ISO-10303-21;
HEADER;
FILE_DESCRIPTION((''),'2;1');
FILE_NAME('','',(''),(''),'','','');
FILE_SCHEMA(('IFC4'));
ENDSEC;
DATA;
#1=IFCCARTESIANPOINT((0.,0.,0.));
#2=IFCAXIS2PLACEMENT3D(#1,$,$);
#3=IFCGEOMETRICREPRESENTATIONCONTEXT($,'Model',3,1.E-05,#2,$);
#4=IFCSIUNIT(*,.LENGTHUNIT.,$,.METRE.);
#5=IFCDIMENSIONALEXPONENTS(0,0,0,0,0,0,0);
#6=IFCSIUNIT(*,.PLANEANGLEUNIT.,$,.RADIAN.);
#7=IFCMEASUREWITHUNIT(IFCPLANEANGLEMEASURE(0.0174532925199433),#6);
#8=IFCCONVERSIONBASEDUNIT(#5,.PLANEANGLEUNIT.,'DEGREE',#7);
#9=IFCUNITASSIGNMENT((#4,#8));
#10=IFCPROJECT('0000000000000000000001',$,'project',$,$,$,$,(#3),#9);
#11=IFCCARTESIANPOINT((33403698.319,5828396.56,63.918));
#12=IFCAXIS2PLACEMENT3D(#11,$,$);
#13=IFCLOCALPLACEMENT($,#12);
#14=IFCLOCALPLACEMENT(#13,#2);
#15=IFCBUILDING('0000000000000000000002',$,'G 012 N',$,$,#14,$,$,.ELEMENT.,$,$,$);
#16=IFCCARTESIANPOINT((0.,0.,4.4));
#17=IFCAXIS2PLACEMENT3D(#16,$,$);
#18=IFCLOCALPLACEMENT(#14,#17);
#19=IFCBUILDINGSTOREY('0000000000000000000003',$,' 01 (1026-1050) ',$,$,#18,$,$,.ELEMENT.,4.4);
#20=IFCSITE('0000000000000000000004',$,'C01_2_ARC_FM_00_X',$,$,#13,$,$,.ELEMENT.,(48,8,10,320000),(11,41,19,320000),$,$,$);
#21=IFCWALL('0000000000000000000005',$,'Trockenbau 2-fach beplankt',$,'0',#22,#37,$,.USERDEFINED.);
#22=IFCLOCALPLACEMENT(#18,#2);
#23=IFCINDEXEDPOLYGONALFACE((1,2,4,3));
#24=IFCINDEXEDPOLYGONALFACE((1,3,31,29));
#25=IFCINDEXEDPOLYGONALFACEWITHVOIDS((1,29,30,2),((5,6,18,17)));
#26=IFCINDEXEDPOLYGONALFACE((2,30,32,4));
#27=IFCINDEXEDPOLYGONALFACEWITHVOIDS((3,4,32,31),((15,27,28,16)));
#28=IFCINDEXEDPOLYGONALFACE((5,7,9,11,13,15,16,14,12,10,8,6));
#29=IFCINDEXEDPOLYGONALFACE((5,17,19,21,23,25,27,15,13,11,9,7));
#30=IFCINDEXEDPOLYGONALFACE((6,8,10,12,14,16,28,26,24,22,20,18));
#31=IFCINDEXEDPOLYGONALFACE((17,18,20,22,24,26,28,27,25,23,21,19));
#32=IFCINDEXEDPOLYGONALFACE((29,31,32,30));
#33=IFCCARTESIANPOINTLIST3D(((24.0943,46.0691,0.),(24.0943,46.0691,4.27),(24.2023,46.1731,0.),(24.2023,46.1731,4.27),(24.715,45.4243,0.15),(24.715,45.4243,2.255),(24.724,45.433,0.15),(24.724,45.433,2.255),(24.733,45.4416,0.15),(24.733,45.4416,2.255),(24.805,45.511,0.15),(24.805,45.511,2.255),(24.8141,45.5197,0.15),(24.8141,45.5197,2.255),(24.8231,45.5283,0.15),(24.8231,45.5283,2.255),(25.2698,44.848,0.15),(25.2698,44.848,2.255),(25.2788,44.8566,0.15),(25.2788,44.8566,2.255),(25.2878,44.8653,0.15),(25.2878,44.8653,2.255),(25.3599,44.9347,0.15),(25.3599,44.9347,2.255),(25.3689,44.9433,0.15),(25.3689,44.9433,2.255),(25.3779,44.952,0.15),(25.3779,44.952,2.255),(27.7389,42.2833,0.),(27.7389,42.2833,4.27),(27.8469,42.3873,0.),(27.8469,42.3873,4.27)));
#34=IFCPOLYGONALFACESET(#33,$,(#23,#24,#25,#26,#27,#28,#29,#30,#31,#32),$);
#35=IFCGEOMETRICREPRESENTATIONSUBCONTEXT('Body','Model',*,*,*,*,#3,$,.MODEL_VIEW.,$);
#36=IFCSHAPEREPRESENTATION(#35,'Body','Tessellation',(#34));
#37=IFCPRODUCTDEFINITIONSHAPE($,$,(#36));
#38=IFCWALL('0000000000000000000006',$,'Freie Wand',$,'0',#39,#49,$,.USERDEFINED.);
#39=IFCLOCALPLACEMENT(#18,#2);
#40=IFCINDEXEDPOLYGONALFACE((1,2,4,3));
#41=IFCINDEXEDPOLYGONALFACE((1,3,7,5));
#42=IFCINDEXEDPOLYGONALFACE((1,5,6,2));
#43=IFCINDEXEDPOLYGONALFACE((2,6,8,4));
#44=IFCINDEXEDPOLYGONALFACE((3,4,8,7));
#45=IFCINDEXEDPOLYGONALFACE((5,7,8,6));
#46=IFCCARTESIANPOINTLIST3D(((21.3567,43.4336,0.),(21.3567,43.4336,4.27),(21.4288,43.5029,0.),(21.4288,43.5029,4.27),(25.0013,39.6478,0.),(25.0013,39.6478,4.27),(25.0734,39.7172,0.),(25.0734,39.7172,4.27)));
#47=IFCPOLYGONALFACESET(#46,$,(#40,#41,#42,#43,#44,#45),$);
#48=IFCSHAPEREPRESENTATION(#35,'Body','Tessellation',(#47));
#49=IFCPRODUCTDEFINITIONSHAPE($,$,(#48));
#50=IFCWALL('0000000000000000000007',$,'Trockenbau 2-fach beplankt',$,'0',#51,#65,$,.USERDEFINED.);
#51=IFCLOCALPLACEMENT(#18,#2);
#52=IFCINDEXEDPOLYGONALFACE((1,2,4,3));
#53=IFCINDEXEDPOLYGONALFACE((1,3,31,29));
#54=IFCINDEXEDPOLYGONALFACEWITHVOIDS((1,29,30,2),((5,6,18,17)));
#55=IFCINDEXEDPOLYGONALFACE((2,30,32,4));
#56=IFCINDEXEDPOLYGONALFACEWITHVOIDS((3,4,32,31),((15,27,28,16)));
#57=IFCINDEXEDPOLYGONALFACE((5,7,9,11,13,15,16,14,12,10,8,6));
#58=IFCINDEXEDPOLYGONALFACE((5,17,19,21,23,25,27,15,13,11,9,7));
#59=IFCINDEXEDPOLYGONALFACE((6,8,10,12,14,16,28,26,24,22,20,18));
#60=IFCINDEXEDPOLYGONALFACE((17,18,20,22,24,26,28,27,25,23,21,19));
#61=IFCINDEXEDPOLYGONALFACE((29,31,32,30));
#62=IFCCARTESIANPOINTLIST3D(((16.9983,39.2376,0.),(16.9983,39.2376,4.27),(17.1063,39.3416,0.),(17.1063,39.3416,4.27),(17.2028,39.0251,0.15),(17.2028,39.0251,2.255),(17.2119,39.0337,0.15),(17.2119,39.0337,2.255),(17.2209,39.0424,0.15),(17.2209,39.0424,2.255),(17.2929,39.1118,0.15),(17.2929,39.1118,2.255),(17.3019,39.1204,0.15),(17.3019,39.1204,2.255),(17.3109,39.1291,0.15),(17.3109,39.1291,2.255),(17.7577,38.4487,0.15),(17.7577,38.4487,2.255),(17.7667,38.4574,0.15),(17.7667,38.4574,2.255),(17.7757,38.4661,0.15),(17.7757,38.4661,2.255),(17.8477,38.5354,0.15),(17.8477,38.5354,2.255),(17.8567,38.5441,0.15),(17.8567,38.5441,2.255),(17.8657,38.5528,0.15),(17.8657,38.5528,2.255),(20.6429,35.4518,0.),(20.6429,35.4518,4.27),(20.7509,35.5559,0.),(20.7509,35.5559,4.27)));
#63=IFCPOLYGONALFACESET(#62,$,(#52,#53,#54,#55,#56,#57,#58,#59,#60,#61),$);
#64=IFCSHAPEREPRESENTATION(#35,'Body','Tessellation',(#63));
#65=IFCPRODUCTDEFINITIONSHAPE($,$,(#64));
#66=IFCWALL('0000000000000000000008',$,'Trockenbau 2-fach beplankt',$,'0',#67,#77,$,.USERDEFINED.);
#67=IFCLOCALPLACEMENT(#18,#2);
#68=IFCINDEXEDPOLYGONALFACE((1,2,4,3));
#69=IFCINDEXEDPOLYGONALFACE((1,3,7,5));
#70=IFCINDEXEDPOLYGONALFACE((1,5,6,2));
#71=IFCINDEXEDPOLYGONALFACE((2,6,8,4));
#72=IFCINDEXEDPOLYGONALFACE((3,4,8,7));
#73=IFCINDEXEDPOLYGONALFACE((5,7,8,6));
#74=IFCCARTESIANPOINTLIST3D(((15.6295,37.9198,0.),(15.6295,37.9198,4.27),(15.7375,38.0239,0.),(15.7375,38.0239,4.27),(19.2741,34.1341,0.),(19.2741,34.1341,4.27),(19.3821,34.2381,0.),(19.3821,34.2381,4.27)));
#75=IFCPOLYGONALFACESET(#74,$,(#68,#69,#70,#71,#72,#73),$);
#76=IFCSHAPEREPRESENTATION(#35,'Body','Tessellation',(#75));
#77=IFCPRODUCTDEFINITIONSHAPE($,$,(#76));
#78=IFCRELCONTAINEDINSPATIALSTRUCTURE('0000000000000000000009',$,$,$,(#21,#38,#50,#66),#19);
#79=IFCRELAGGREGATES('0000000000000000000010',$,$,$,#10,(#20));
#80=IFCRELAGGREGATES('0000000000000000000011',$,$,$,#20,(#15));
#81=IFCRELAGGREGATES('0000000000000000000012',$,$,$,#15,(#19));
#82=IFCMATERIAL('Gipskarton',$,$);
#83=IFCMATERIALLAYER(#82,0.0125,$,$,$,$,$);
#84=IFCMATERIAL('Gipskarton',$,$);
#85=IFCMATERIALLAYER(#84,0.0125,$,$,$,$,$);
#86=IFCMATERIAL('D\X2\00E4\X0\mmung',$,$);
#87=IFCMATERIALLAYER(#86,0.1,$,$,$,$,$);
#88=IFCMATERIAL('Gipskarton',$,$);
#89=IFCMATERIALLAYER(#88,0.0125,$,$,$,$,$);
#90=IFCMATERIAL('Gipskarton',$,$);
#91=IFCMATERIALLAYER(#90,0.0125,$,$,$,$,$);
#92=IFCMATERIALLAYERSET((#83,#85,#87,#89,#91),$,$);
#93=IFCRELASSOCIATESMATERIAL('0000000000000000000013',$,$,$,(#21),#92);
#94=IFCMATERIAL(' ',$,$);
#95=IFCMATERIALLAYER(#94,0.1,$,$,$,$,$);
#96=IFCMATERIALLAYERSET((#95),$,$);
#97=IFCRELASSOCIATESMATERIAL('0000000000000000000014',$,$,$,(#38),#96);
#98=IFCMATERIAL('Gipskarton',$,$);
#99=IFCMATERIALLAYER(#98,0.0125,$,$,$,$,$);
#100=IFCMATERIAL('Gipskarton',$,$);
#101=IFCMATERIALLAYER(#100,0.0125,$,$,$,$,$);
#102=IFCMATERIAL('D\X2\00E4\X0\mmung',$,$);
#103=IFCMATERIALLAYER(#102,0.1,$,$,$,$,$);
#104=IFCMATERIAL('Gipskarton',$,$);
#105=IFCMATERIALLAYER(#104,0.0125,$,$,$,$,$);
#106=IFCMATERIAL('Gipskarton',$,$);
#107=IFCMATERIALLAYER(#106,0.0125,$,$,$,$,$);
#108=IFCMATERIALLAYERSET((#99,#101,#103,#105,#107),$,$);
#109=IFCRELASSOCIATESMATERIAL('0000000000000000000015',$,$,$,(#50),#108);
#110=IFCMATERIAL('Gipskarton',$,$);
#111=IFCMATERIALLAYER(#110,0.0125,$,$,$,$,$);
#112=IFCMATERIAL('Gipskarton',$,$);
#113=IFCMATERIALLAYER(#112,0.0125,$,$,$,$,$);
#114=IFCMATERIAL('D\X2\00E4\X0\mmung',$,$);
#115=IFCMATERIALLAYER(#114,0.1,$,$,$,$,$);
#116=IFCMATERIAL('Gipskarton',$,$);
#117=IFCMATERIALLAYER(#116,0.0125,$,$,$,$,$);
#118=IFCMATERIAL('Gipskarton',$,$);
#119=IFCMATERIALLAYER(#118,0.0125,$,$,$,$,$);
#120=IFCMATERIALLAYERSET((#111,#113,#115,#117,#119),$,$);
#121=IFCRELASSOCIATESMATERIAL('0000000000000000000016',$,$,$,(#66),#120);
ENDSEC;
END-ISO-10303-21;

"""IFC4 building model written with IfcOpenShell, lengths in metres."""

from ifc_helpers import new_model, entity, si_unit, converted_unit, frame, frame_2d, origin, origin_with_axes, place, context, subcontext, project, spatial, polyline, rectangle, outline, extrude, material, layer, layer_set, layer_usage, element, save


model = new_model("IFC4")

# Units and contexts
model_context = context("Model", 3, precision=1e-05, world=origin())
body_context = subcontext(model_context, "Body", "Model", "MODEL_VIEW")
ifc_project = project(units=[si_unit("LENGTHUNIT", "METRE"), converted_unit("PLANEANGLEUNIT", "DEGREE", entity("IfcPlaneAngleMeasure", 0.0174532925199433), si_unit("PLANEANGLEUNIT", "RADIAN"), dimensions=[0, 0, 0, 0, 0, 0, 0])], contexts=[model_context])

# Site, building, storey
site_placement = place(None, frame((33403698.319, 5828396.56, 63.918)))
site = spatial("IfcSite", under=ifc_project, at=site_placement, Name="C01_2_ARC_FM_00_X", CompositionType="ELEMENT", RefLatitude=(48, 8, 10, 320000), RefLongitude=(11, 41, 19, 320000))
building_placement = place(site_placement, origin())
building = spatial("IfcBuilding", under=site, at=building_placement, Name="G 012 N", CompositionType="ELEMENT")
storey_placement = place(building_placement, frame((0.0, 0.0, 4.4)))
storey = spatial("IfcBuildingStorey", under=building, at=storey_placement, Name=" 01 (1026-1050) ", CompositionType="ELEMENT", Elevation=4.4)

# Wall, opening
ifc_material_1 = material(Name="Gipskarton")
ifc_layer_1 = layer(ifc_material_1, 0.0125)
ifc_material_2 = material(Name="Gipskarton")
ifc_layer_2 = layer(ifc_material_2, 0.0125)
ifc_material_3 = material(Name="Dämmung")
ifc_layer_3 = layer(ifc_material_3, 0.1)
ifc_material_4 = material(Name="Gipskarton")
ifc_layer_4 = layer(ifc_material_4, 0.0125)
ifc_material_5 = material(Name="Gipskarton")
ifc_layer_5 = layer(ifc_material_5, 0.0125)
ifc_layer_set_1 = layer_set([ifc_layer_1, ifc_layer_2, ifc_layer_3, ifc_layer_4, ifc_layer_5])
ifc_layer_usage_1 = layer_usage(ifc_layer_set_1, "AXIS2", "POSITIVE", 0.0)
wall_1_placement = place(storey_placement, frame((27.8469, 42.3873, 0.0), z_axis=(0.0, 0.0, 1.0), x_axis=(-0.693551, 0.720408, 0.0)))
wall_1 = element("IfcWall", 1, at=wall_1_placement, inside=storey, material=ifc_layer_usage_1, Name="Trockenbau 2-fach beplankt", ObjectType="0", PredefinedType="USERDEFINED", context=body_context, shape_type="SweptSolid", body=[
    extrude(rectangle(XDim=5.255, YDim=0.15, at=frame_2d((2.6275, 0.075), x_axis=(1.0, 0.0))), origin_with_axes(), (0.0, 0.0, 1.0), 4.27),
])
opening_1_placement = place(wall_1_placement, frame((4.36, 0.0125, 0.15), z_axis=(0.0, -1.0, 0.0), x_axis=(0.0, 0.0, 1.0)))
element("IfcOpeningElement", 2, at=opening_1_placement, cuts=wall_1, ObjectType="0", PredefinedType="USERDEFINED", context=body_context, shape_type="SweptSolid", body=[
    extrude(outline(polyline([(0.0, 0.8), (2.105, 0.8), (2.105, 0.0), (0.0, 0.0), (0.0, 0.8)])), origin_with_axes(), (0.0, 0.0, 1.0), 0.0125),
    extrude(outline(polyline([(0.0, 0.8), (2.105, 0.8), (2.105, 0.0), (0.0, 0.0), (0.0, 0.8)])), frame((0.0, 0.0, -0.0125), z_axis=(0.0, 0.0, 1.0), x_axis=(1.0, 0.0, 0.0)), (0.0, 0.0, 1.0), 0.0125),
    extrude(outline(polyline([(0.0, 0.8), (2.105, 0.8), (2.105, 0.0), (0.0, 0.0), (0.0, 0.8)])), frame((0.0, 0.0, -0.1125), z_axis=(0.0, 0.0, 1.0), x_axis=(1.0, 0.0, 0.0)), (0.0, 0.0, 1.0), 0.1),
    extrude(outline(polyline([(0.0, 0.8), (2.105, 0.8), (2.105, 0.0), (0.0, 0.0), (0.0, 0.8)])), frame((0.0, 0.0, -0.125), z_axis=(0.0, 0.0, 1.0), x_axis=(1.0, 0.0, 0.0)), (0.0, 0.0, 1.0), 0.0125),
    extrude(outline(polyline([(0.0, 0.8), (2.105, 0.8), (2.105, 0.0), (0.0, 0.0), (0.0, 0.8)])), frame((0.0, 0.0, -0.1375), z_axis=(0.0, 0.0, 1.0), x_axis=(1.0, 0.0, 0.0)), (0.0, 0.0, 1.0), 0.0125),
])

# Wall
ifc_material_6 = material(Name=" ")
ifc_layer_6 = layer(ifc_material_6, 0.1)
ifc_layer_set_2 = layer_set([ifc_layer_6])
ifc_layer_usage_2 = layer_usage(ifc_layer_set_2, "AXIS2", "POSITIVE", 0.0)
wall_2_placement = place(storey_placement, frame((25.0734, 39.7172, 0.0), z_axis=(0.0, 0.0, 1.0), x_axis=(-0.693551, 0.720408, 0.0)))
element("IfcWall", 3, at=wall_2_placement, inside=storey, material=ifc_layer_usage_2, Name="Freie Wand", ObjectType="0", PredefinedType="USERDEFINED", context=body_context, shape_type="SweptSolid", body=[
    extrude(rectangle(XDim=5.255, YDim=0.1, at=frame_2d((2.6275, 0.05), x_axis=(1.0, 0.0))), origin_with_axes(), (0.0, 0.0, 1.0), 4.27),
])

# Wall, opening
ifc_material_7 = material(Name="Gipskarton")
ifc_layer_7 = layer(ifc_material_7, 0.0125)
ifc_material_8 = material(Name="Gipskarton")
ifc_layer_8 = layer(ifc_material_8, 0.0125)
ifc_material_9 = material(Name="Dämmung")
ifc_layer_9 = layer(ifc_material_9, 0.1)
ifc_material_10 = material(Name="Gipskarton")
ifc_layer_10 = layer(ifc_material_10, 0.0125)
ifc_material_11 = material(Name="Gipskarton")
ifc_layer_11 = layer(ifc_material_11, 0.0125)
ifc_layer_set_3 = layer_set([ifc_layer_7, ifc_layer_8, ifc_layer_9, ifc_layer_10, ifc_layer_11])
ifc_layer_usage_3 = layer_usage(ifc_layer_set_3, "AXIS2", "POSITIVE", 0.0)
wall_3_placement = place(storey_placement, frame((20.7509, 35.5559, 0.0), z_axis=(0.0, 0.0, 1.0), x_axis=(-0.693551, 0.720408, 0.0)))
wall_3 = element("IfcWall", 4, at=wall_3_placement, inside=storey, material=ifc_layer_usage_3, Name="Trockenbau 2-fach beplankt", ObjectType="0", PredefinedType="USERDEFINED", context=body_context, shape_type="SweptSolid", body=[
    extrude(rectangle(XDim=5.255, YDim=0.15, at=frame_2d((2.6275, 0.075), x_axis=(1.0, 0.0))), origin_with_axes(), (0.0, 0.0, 1.0), 4.27),
])
opening_2_placement = place(wall_3_placement, frame((4.96, 0.0125, 0.15), z_axis=(0.0, -1.0, 0.0), x_axis=(0.0, 0.0, 1.0)))
element("IfcOpeningElement", 5, at=opening_2_placement, cuts=wall_3, ObjectType="0", PredefinedType="USERDEFINED", context=body_context, shape_type="SweptSolid", body=[
    extrude(outline(polyline([(0.0, 0.8), (2.105, 0.8), (2.105, 0.0), (0.0, 0.0), (0.0, 0.8)])), origin_with_axes(), (0.0, 0.0, 1.0), 0.0125),
    extrude(outline(polyline([(0.0, 0.8), (2.105, 0.8), (2.105, 0.0), (0.0, 0.0), (0.0, 0.8)])), frame((0.0, 0.0, -0.0125), z_axis=(0.0, 0.0, 1.0), x_axis=(1.0, 0.0, 0.0)), (0.0, 0.0, 1.0), 0.0125),
    extrude(outline(polyline([(0.0, 0.8), (2.105, 0.8), (2.105, 0.0), (0.0, 0.0), (0.0, 0.8)])), frame((0.0, 0.0, -0.1125), z_axis=(0.0, 0.0, 1.0), x_axis=(1.0, 0.0, 0.0)), (0.0, 0.0, 1.0), 0.1),
    extrude(outline(polyline([(0.0, 0.8), (2.105, 0.8), (2.105, 0.0), (0.0, 0.0), (0.0, 0.8)])), frame((0.0, 0.0, -0.125), z_axis=(0.0, 0.0, 1.0), x_axis=(1.0, 0.0, 0.0)), (0.0, 0.0, 1.0), 0.0125),
    extrude(outline(polyline([(0.0, 0.8), (2.105, 0.8), (2.105, 0.0), (0.0, 0.0), (0.0, 0.8)])), frame((0.0, 0.0, -0.1375), z_axis=(0.0, 0.0, 1.0), x_axis=(1.0, 0.0, 0.0)), (0.0, 0.0, 1.0), 0.0125),
])

# Wall
ifc_material_12 = material(Name="Gipskarton")
ifc_layer_12 = layer(ifc_material_12, 0.0125)
ifc_material_13 = material(Name="Gipskarton")
ifc_layer_13 = layer(ifc_material_13, 0.0125)
ifc_material_14 = material(Name="Dämmung")
ifc_layer_14 = layer(ifc_material_14, 0.1)
ifc_material_15 = material(Name="Gipskarton")
ifc_layer_15 = layer(ifc_material_15, 0.0125)
ifc_material_16 = material(Name="Gipskarton")
ifc_layer_16 = layer(ifc_material_16, 0.0125)
ifc_layer_set_4 = layer_set([ifc_layer_12, ifc_layer_13, ifc_layer_14, ifc_layer_15, ifc_layer_16])
ifc_layer_usage_4 = layer_usage(ifc_layer_set_4, "AXIS2", "POSITIVE", 0.0)
wall_4_placement = place(storey_placement, frame((19.3821, 34.2381, 0.0), z_axis=(0.0, 0.0, 1.0), x_axis=(-0.693551, 0.720408, 0.0)))
element("IfcWall", 6, at=wall_4_placement, inside=storey, material=ifc_layer_usage_4, Name="Trockenbau 2-fach beplankt", ObjectType="0", PredefinedType="USERDEFINED", context=body_context, shape_type="SweptSolid", body=[
    extrude(rectangle(XDim=5.255, YDim=0.15, at=frame_2d((2.6275, 0.075), x_axis=(1.0, 0.0))), origin_with_axes(), (0.0, 0.0, 1.0), 4.27),
])

save(model, "model.ifc")
